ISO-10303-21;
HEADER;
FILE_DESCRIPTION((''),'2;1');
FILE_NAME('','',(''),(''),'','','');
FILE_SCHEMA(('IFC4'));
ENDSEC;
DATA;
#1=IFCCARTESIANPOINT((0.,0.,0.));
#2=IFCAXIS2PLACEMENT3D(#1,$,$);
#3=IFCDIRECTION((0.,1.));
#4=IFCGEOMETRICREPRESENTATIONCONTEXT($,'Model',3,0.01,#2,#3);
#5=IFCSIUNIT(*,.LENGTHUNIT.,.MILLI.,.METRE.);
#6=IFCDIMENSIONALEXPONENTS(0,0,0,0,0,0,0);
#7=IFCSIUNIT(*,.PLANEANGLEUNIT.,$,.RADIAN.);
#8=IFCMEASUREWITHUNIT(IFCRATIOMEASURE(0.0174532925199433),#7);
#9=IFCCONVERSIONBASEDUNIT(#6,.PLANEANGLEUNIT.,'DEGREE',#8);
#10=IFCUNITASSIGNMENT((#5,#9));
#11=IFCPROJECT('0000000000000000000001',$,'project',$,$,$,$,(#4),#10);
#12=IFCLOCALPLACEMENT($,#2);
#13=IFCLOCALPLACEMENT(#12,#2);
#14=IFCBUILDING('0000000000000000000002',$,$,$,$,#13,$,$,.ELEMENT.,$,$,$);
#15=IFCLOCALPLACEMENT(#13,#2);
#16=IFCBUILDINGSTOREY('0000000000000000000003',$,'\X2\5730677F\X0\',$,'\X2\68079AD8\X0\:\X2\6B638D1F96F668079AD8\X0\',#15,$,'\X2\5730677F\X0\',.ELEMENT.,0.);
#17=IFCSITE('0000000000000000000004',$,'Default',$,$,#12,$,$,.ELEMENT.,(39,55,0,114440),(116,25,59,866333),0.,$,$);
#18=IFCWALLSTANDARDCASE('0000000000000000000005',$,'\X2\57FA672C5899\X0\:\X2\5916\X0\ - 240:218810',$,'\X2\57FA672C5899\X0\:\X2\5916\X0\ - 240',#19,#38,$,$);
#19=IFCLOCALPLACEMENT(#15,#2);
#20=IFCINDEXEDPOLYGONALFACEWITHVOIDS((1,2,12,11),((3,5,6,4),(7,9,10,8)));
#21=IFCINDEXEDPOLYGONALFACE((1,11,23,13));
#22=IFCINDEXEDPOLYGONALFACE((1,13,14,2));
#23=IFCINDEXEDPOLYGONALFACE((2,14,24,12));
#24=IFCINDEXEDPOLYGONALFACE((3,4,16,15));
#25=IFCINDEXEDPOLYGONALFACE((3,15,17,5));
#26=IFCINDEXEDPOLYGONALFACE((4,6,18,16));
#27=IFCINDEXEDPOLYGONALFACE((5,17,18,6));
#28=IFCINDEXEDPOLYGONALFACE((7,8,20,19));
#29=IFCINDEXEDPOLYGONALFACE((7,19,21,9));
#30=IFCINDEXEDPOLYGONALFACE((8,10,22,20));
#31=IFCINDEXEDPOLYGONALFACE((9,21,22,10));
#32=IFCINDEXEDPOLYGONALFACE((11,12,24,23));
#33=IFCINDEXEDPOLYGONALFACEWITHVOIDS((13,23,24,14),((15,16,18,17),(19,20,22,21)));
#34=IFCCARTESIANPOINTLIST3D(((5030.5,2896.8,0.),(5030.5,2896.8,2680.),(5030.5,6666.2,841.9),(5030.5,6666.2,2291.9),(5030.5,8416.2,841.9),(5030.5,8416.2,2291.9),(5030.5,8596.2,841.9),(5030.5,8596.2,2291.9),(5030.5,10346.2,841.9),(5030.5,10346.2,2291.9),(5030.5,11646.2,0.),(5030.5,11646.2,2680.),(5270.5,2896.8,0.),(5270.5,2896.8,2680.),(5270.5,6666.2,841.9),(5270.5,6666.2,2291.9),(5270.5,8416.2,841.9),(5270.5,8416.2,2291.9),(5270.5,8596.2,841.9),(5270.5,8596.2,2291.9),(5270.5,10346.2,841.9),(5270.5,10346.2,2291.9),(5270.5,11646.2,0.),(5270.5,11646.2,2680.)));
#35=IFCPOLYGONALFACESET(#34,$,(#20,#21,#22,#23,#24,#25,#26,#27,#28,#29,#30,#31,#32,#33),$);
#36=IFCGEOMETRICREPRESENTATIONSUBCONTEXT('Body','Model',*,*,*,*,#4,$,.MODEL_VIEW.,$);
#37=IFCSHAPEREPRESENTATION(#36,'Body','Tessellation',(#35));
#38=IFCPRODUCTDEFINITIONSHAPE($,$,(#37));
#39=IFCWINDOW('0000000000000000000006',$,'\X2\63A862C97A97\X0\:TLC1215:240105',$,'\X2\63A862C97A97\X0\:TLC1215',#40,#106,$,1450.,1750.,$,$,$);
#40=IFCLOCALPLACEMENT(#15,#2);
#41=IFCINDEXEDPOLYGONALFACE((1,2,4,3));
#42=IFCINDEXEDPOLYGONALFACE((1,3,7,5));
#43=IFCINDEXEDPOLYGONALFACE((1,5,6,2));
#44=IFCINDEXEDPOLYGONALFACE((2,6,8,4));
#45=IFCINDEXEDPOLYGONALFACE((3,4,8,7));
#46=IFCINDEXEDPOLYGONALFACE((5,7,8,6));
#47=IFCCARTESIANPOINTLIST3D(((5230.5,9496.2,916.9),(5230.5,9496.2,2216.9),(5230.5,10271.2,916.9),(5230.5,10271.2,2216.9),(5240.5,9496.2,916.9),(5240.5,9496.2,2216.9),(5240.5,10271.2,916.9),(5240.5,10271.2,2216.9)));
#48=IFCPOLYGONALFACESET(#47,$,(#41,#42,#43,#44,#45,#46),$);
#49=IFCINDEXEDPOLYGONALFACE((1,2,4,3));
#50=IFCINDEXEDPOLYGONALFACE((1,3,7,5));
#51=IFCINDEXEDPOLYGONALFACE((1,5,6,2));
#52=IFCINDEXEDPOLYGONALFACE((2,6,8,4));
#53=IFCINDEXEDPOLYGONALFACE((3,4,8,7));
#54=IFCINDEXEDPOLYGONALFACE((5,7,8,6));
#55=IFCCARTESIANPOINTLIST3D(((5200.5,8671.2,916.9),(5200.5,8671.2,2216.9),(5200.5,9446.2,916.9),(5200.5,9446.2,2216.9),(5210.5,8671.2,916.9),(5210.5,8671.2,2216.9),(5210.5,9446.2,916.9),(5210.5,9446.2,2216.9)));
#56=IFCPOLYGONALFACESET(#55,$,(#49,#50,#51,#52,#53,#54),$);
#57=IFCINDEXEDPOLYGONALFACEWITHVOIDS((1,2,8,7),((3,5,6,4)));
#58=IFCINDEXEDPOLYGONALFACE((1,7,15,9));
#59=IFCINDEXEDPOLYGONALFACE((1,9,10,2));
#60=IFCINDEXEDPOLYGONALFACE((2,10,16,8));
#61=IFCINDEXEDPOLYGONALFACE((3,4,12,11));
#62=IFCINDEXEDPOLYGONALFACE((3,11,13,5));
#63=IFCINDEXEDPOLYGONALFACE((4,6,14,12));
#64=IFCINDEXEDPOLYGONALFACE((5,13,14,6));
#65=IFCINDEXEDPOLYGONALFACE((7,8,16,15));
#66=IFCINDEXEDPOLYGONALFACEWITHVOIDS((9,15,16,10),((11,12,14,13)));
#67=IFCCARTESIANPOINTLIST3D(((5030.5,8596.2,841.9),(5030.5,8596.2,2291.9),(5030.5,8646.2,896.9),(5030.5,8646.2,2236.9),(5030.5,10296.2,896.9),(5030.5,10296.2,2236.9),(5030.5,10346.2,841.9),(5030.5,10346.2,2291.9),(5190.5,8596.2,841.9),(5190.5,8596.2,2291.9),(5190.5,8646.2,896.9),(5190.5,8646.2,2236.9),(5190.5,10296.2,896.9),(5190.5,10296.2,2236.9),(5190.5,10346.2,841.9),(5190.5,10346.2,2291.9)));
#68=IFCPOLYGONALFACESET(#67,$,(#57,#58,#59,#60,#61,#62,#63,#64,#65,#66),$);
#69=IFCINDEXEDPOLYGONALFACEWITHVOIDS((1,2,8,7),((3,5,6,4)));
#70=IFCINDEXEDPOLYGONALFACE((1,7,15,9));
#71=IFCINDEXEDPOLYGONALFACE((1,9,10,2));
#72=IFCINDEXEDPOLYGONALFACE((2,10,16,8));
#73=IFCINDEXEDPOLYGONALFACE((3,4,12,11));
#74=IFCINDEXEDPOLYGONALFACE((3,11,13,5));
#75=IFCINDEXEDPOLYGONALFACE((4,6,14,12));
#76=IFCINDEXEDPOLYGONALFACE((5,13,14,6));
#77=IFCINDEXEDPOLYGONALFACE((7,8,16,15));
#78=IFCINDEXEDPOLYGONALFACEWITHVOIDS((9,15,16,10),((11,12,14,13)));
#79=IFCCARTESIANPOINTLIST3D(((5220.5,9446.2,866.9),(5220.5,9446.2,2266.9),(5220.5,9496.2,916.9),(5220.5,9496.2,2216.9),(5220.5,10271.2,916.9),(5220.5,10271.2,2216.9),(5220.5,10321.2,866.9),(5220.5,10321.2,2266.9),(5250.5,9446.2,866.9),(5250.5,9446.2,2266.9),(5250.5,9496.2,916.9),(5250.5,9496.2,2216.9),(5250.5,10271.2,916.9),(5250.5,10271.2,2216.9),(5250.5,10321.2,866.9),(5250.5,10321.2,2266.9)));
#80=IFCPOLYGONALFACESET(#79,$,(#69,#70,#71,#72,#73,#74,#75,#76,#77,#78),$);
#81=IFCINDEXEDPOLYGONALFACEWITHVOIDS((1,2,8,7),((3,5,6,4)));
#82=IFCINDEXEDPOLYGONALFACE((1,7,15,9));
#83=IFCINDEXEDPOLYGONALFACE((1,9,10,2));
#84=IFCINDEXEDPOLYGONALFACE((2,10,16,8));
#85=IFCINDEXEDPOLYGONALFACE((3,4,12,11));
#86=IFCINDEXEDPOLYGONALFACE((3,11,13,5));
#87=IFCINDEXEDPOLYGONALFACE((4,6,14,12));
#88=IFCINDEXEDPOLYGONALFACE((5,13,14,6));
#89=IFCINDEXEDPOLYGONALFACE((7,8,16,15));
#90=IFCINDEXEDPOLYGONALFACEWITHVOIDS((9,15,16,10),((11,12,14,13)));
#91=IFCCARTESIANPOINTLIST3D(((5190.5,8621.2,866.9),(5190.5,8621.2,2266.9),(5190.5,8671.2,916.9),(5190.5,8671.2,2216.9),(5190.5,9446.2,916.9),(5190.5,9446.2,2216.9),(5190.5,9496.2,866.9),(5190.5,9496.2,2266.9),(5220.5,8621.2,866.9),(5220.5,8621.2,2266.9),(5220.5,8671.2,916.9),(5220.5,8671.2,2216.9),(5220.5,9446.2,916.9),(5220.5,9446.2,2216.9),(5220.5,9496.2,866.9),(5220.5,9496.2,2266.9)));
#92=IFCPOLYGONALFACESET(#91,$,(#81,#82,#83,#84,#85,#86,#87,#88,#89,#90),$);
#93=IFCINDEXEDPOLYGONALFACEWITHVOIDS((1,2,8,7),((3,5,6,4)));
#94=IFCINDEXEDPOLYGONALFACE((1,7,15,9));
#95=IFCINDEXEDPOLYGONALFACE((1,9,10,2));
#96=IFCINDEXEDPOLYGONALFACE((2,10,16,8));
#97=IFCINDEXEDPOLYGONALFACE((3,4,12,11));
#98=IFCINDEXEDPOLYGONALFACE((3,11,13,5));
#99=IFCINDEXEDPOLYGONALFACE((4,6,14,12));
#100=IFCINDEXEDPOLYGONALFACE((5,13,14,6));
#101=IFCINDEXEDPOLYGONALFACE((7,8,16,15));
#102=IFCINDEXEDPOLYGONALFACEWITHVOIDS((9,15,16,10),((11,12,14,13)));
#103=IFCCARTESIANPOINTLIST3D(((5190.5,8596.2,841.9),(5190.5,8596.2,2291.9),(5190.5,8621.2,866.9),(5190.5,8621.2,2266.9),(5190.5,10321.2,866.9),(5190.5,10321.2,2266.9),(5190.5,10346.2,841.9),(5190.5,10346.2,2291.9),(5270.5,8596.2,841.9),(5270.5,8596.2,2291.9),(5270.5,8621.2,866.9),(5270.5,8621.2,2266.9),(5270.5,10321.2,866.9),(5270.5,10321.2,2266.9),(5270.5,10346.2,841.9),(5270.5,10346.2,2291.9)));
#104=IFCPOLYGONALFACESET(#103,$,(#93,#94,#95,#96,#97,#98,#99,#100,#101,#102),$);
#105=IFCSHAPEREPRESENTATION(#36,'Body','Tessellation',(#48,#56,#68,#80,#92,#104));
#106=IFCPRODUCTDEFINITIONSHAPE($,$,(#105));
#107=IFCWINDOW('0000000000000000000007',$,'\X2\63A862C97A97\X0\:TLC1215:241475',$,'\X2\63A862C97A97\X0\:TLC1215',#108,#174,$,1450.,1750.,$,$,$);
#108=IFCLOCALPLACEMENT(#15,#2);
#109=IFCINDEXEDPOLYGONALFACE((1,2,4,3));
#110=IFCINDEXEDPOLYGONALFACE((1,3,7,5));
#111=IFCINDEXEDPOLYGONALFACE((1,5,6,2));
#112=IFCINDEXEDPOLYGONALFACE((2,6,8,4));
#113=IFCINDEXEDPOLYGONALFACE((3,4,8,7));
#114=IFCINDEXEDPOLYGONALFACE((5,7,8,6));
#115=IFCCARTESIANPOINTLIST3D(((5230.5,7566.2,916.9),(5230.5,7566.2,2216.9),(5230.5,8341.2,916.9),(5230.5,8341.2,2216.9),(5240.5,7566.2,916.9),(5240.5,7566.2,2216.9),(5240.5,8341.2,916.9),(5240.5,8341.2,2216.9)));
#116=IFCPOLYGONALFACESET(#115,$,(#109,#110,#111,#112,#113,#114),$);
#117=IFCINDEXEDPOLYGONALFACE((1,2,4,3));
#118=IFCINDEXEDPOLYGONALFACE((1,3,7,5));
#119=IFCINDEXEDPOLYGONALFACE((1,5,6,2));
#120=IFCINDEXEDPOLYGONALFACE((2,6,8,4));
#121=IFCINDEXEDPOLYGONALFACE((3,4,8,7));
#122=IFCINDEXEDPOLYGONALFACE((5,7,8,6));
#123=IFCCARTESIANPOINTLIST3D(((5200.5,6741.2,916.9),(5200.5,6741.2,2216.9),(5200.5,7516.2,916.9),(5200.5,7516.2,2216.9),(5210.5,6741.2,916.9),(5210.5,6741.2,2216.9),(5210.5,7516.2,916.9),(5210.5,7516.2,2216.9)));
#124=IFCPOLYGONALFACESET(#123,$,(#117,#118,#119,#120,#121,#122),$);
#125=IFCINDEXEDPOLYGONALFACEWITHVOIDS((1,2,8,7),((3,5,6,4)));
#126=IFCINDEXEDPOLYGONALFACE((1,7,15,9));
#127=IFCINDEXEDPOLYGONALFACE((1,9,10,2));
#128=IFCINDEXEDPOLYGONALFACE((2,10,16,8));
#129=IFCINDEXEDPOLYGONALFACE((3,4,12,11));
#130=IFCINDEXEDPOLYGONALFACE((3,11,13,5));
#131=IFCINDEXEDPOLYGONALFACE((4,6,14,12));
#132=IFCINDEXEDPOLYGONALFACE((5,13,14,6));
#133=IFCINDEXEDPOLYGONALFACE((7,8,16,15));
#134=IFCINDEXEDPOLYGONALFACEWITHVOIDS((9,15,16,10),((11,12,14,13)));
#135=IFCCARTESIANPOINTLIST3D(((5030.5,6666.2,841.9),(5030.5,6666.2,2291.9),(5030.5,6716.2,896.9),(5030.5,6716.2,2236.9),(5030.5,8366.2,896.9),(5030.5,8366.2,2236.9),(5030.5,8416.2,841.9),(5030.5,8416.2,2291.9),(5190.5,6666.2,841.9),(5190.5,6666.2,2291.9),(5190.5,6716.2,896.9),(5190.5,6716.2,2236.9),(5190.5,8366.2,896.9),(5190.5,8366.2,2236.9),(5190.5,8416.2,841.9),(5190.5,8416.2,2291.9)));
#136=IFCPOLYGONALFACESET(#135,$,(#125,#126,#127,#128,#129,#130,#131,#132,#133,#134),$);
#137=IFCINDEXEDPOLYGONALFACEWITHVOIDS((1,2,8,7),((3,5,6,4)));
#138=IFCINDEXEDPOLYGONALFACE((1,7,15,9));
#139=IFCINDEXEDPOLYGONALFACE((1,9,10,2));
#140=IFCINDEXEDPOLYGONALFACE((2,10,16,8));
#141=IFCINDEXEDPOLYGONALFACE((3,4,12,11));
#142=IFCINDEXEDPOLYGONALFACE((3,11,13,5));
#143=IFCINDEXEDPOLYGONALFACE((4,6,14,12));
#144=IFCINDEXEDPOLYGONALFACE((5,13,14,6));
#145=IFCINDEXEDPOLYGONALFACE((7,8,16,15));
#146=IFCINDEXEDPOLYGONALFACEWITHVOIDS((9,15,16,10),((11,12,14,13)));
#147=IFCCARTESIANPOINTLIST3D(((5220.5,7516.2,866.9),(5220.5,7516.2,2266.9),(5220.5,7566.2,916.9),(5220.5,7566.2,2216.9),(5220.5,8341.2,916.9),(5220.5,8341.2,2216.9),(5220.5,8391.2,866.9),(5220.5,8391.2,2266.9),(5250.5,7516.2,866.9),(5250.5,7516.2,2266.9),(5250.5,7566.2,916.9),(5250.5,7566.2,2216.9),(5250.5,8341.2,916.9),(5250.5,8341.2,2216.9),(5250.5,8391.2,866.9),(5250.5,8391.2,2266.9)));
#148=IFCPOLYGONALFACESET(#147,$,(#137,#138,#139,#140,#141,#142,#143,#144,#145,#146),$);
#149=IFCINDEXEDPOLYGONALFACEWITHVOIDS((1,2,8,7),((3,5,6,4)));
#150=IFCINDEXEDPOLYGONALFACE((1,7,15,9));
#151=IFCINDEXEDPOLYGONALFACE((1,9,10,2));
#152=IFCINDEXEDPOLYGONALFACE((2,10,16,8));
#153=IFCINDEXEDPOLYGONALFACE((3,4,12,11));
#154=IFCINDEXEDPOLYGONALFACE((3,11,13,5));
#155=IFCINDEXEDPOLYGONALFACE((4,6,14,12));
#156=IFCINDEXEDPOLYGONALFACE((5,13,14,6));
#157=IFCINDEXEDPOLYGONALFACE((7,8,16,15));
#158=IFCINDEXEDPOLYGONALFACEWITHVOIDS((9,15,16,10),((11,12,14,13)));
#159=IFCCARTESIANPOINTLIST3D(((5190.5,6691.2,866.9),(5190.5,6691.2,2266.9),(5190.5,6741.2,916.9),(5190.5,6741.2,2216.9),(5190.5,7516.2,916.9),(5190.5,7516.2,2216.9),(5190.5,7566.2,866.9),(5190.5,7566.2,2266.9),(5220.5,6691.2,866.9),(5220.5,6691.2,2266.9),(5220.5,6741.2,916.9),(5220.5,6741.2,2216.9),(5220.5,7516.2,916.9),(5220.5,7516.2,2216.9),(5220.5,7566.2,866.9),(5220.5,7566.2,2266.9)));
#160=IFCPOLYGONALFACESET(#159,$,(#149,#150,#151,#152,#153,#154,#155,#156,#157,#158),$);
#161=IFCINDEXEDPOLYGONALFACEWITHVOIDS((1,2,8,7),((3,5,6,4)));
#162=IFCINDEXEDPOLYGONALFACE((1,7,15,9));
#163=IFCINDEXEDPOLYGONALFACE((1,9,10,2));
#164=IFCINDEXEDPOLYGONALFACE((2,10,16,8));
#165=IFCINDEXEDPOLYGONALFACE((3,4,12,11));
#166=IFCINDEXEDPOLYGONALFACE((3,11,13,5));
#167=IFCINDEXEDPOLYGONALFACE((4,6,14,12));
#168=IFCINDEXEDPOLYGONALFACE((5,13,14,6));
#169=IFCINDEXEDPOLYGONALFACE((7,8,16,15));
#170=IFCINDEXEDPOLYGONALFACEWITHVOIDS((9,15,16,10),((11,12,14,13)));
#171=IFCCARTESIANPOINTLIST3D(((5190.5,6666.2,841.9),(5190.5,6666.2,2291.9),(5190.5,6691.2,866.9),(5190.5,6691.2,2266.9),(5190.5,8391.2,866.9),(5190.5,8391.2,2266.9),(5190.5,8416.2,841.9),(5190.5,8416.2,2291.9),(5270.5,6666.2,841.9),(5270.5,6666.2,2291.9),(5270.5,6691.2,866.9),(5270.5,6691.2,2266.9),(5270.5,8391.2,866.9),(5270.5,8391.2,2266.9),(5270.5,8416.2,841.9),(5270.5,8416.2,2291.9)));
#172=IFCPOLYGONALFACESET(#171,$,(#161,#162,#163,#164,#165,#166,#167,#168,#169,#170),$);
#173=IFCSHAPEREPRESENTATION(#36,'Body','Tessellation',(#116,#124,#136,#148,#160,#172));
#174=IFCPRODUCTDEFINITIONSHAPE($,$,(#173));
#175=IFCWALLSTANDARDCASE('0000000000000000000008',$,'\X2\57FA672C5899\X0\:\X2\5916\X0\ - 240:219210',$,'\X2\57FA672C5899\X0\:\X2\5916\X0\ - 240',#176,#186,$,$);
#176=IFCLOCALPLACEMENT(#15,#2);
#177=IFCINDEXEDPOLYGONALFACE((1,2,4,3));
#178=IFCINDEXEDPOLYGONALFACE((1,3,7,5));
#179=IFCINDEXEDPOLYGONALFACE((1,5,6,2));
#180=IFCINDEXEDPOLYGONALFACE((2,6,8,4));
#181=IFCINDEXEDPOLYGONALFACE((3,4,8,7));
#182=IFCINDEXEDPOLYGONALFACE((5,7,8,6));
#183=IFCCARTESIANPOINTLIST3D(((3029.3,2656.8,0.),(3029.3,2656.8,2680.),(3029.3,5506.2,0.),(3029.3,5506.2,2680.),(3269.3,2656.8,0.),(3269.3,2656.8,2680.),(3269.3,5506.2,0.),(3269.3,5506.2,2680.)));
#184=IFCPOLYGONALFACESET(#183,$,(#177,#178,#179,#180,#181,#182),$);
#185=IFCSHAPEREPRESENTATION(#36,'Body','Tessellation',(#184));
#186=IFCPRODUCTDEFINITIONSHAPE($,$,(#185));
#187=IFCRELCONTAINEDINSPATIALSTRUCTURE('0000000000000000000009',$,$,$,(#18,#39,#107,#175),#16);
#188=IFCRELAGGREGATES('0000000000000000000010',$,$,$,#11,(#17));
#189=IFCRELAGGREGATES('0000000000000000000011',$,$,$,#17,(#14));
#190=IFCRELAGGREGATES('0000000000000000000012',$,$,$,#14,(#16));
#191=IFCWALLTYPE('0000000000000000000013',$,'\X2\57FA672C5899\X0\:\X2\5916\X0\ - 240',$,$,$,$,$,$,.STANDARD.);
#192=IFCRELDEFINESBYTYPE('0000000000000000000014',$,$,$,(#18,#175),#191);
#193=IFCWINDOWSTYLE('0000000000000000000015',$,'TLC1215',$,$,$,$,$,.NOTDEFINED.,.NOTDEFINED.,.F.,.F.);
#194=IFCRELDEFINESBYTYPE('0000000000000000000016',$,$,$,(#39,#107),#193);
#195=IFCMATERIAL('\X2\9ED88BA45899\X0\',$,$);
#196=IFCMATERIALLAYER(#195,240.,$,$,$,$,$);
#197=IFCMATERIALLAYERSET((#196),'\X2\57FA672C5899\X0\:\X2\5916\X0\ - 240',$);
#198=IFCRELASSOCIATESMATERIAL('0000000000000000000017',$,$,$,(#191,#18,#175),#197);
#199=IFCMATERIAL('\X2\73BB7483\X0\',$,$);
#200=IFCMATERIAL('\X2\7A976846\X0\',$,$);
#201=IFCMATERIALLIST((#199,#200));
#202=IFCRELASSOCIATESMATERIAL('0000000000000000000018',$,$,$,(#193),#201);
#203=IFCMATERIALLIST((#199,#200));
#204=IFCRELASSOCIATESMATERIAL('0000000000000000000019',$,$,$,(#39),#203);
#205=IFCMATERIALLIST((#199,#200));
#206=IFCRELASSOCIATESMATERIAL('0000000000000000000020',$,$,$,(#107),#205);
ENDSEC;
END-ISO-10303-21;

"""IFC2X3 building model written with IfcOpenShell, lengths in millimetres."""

from ifc_helpers import new_model, entity, si_unit, converted_unit, direction, frame, frame_2d, origin, origin_2d_with_axis, place, context, subcontext, project, spatial, polyline, rectangle, outline, extrude, source, transform, mapped, material, material_list, layer, layer_set, layer_usage, type_object, type_shapes, element, fill, save


model = new_model("IFC2X3")

# Units and contexts
model_context = context("Model", 3, precision=0.01, world=origin(), true_north=direction((0.0, 1.0)))
body_context = subcontext(model_context, "Body", "Model", "MODEL_VIEW")
ifc_project = project(units=[si_unit("LENGTHUNIT", "METRE", prefix="MILLI"), converted_unit("PLANEANGLEUNIT", "DEGREE", entity("IfcRatioMeasure", 0.0174532925199433), si_unit("PLANEANGLEUNIT", "RADIAN"), dimensions=[0, 0, 0, 0, 0, 0, 0])], contexts=[model_context])

# Site, building, storey
site_placement = place(None, origin())
site = spatial("IfcSite", under=ifc_project, at=site_placement, Name="Default", CompositionType="ELEMENT", RefLatitude=(39, 55, 0, 114440), RefLongitude=(116, 25, 59, 866333), RefElevation=0.0)
building_placement = place(site_placement, origin())
building = spatial("IfcBuilding", under=site, at=building_placement, CompositionType="ELEMENT")
storey_placement = place(building_placement, origin())
storey = spatial("IfcBuildingStorey", under=building, at=storey_placement, Name="地板", ObjectType="标高:正负零标高", LongName="地板", CompositionType="ELEMENT", Elevation=0.0)

# Wall, openings, windows
ifc_material_1 = material(Name="默认墙")
ifc_layer_1 = layer(ifc_material_1, 240.0)
ifc_layer_set_1 = layer_set([ifc_layer_1], Name="基本墙:外 - 240")
wall_type_1 = type_object("IfcWallType", Name="基本墙:外 - 240", PredefinedType="STANDARD", material=ifc_layer_set_1)
ifc_material_2 = material(Name="玻璃")
ifc_material_3 = material(Name="窗框")
ifc_layer_usage_1 = layer_usage(ifc_layer_set_1, "AXIS2", "NEGATIVE", 120.0)
wall_1_placement = place(storey_placement, frame((5150.5, 11646.2, 0.0), z_axis=(0.0, 0.0, 1.0), x_axis=(0.0, -1.0, 0.0)))
wall_1 = element("IfcWallStandardCase", 1, at=wall_1_placement, inside=storey, type_object=wall_type_1, material=ifc_layer_usage_1, Name="基本墙:外 - 240:218810", ObjectType="基本墙:外 - 240", context=body_context, shape_type="SweptSolid", body=[
    extrude(rectangle(XDim=8749.4, YDim=240.0, at=frame_2d((4374.7, 0.0), x_axis=(-1.0, 0.0))), origin(), (0.0, 0.0, 1.0), 2680.0),
])
opening_1_placement = place(wall_1_placement, frame((3230.0, -120.0, 841.9)))
opening_1 = element("IfcOpeningElement", 2, at=opening_1_placement, cuts=wall_1, ObjectType="Opening", context=body_context, shape_type="SweptSolid", body=[
    extrude(rectangle(XDim=1450.0, YDim=1750.0, at=frame_2d((725.0, 875.0), x_axis=(-1.0, 0.0))), frame((0.0, 0.0, 0.0), z_axis=(0.0, 1.0, 0.0), x_axis=(0.0, 0.0, 1.0)), (0.0, 0.0, 1.0), 240.0),
])
opening_2_placement = place(wall_1_placement, frame((1300.0, -120.0, 841.9)))
opening_2 = element("IfcOpeningElement", 3, at=opening_2_placement, cuts=wall_1, ObjectType="Opening", context=body_context, shape_type="SweptSolid", body=[
    extrude(rectangle(XDim=1450.0, YDim=1750.0, at=frame_2d((725.0, 875.0), x_axis=(-1.0, 0.0))), frame((0.0, 0.0, 0.0), z_axis=(0.0, 1.0, 0.0), x_axis=(0.0, 0.0, 1.0)), (0.0, 0.0, 1.0), 240.0),
])
ifc_material_list_1 = material_list([ifc_material_2, ifc_material_3])
ifc_material_list_2 = material_list([ifc_material_2, ifc_material_3])
window_style_1 = type_object("IfcWindowStyle", Name="TLC1215", ConstructionType="NOTDEFINED", OperationType="NOTDEFINED", ParameterTakesPrecedence=False, Sizeable=False, material=ifc_material_list_2)
shared_shape_1 = source(origin(), body_context, "Body", "SweptSolid", [
    extrude(rectangle(XDim=10.0, YDim=775.0, at=frame_2d((0.0, 0.0), x_axis=(1.0, 0.0))), frame((462.5, 205.0, 75.0), z_axis=(0.0, 0.0, 1.0), x_axis=(0.0, -1.0, 0.0)), (0.0, 0.0, 1.0), 1300.0),
    extrude(rectangle(XDim=10.0, YDim=775.0, at=origin_2d_with_axis()), frame((1287.5, 175.0, 75.0), z_axis=(0.0, 0.0, 1.0), x_axis=(0.0, -1.0, 0.0)), (0.0, 0.0, 1.0), 1300.0),
    extrude(outline(polyline([(-875.0, -725.0), (875.0, -725.0), (875.0, 725.0), (-875.0, 725.0), (-875.0, -725.0)]), holes=[polyline([(825.0, -670.0), (-825.0, -670.0), (-825.0, 670.0), (825.0, 670.0), (825.0, -670.0)])]), frame((875.0, 0.0, 725.0), z_axis=(0.0, 1.0, 0.0), x_axis=(1.0, 0.0, 0.0)), (0.0, 0.0, 1.0), 160.0),
    extrude(outline(polyline([(-437.5, -700.0), (437.5, -700.0), (437.5, 700.0), (-437.5, 700.0), (-437.5, -700.0)]), holes=[polyline([(-387.5, -650.0), (-387.5, 650.0), (387.5, 650.0), (387.5, -650.0), (-387.5, -650.0)])]), frame((462.5, 190.0, 725.0), z_axis=(0.0, 1.0, 0.0), x_axis=(-1.0, 0.0, 0.0)), (0.0, 0.0, 1.0), 30.0),
    extrude(outline(polyline([(-437.5, -700.0), (437.5, -700.0), (437.5, 700.0), (-437.5, 700.0), (-437.5, -700.0)]), holes=[polyline([(-387.5, -650.0), (-387.5, 650.0), (387.5, 650.0), (387.5, -650.0), (-387.5, -650.0)])]), frame((1287.5, 160.0, 725.0), z_axis=(0.0, 1.0, 0.0), x_axis=(1.0, 0.0, 0.0)), (0.0, 0.0, 1.0), 30.0),
    extrude(outline(polyline([(-875.0, -725.0), (875.0, -725.0), (875.0, 725.0), (-875.0, 725.0), (-875.0, -725.0)]), holes=[polyline([(-850.0, 700.0), (850.0, 700.0), (850.0, -700.0), (-850.0, -700.0), (-850.0, 700.0)])]), frame((875.0, 160.0, 725.0), z_axis=(0.0, 1.0, 0.0), x_axis=(1.0, 0.0, 0.0)), (0.0, 0.0, 1.0), 80.0),
])
type_shapes(window_style_1, [shared_shape_1])
window_1_placement = place(opening_2_placement, origin())
window_1 = element("IfcWindow", 4, at=window_1_placement, inside=storey, type_object=window_style_1, material=ifc_material_list_1, Name="推拉窗:TLC1215:240105", ObjectType="推拉窗:TLC1215", OverallHeight=1450.0, OverallWidth=1750.0, context=body_context, shape_type="MappedRepresentation", body=[
    mapped(shared_shape_1, transform((0.0, 0.0, 0.0), scale=1.0)),
])
fill(opening_2, window_1)
ifc_material_list_3 = material_list([ifc_material_2, ifc_material_3])
window_2_placement = place(opening_1_placement, origin())
window_2 = element("IfcWindow", 5, at=window_2_placement, inside=storey, type_object=window_style_1, material=ifc_material_list_3, Name="推拉窗:TLC1215:241475", ObjectType="推拉窗:TLC1215", OverallHeight=1450.0, OverallWidth=1750.0, context=body_context, shape_type="MappedRepresentation", body=[
    mapped(shared_shape_1, transform((0.0, 0.0, 0.0), scale=1.0)),
])
fill(opening_1, window_2)

# Wall
ifc_layer_usage_2 = layer_usage(ifc_layer_set_1, "AXIS2", "NEGATIVE", 120.0)
wall_2_placement = place(storey_placement, frame((3149.3, 5506.2, 0.0), z_axis=(0.0, 0.0, 1.0), x_axis=(0.0, -1.0, 0.0)))
element("IfcWallStandardCase", 6, at=wall_2_placement, inside=storey, type_object=wall_type_1, material=ifc_layer_usage_2, Name="基本墙:外 - 240:219210", ObjectType="基本墙:外 - 240", context=body_context, shape_type="SweptSolid", body=[
    extrude(rectangle(XDim=2849.4, YDim=240.0, at=frame_2d((1424.7, 0.0), x_axis=(-1.0, 0.0))), origin(), (0.0, 0.0, 1.0), 2680.0),
])

save(model, "model.ifc")
